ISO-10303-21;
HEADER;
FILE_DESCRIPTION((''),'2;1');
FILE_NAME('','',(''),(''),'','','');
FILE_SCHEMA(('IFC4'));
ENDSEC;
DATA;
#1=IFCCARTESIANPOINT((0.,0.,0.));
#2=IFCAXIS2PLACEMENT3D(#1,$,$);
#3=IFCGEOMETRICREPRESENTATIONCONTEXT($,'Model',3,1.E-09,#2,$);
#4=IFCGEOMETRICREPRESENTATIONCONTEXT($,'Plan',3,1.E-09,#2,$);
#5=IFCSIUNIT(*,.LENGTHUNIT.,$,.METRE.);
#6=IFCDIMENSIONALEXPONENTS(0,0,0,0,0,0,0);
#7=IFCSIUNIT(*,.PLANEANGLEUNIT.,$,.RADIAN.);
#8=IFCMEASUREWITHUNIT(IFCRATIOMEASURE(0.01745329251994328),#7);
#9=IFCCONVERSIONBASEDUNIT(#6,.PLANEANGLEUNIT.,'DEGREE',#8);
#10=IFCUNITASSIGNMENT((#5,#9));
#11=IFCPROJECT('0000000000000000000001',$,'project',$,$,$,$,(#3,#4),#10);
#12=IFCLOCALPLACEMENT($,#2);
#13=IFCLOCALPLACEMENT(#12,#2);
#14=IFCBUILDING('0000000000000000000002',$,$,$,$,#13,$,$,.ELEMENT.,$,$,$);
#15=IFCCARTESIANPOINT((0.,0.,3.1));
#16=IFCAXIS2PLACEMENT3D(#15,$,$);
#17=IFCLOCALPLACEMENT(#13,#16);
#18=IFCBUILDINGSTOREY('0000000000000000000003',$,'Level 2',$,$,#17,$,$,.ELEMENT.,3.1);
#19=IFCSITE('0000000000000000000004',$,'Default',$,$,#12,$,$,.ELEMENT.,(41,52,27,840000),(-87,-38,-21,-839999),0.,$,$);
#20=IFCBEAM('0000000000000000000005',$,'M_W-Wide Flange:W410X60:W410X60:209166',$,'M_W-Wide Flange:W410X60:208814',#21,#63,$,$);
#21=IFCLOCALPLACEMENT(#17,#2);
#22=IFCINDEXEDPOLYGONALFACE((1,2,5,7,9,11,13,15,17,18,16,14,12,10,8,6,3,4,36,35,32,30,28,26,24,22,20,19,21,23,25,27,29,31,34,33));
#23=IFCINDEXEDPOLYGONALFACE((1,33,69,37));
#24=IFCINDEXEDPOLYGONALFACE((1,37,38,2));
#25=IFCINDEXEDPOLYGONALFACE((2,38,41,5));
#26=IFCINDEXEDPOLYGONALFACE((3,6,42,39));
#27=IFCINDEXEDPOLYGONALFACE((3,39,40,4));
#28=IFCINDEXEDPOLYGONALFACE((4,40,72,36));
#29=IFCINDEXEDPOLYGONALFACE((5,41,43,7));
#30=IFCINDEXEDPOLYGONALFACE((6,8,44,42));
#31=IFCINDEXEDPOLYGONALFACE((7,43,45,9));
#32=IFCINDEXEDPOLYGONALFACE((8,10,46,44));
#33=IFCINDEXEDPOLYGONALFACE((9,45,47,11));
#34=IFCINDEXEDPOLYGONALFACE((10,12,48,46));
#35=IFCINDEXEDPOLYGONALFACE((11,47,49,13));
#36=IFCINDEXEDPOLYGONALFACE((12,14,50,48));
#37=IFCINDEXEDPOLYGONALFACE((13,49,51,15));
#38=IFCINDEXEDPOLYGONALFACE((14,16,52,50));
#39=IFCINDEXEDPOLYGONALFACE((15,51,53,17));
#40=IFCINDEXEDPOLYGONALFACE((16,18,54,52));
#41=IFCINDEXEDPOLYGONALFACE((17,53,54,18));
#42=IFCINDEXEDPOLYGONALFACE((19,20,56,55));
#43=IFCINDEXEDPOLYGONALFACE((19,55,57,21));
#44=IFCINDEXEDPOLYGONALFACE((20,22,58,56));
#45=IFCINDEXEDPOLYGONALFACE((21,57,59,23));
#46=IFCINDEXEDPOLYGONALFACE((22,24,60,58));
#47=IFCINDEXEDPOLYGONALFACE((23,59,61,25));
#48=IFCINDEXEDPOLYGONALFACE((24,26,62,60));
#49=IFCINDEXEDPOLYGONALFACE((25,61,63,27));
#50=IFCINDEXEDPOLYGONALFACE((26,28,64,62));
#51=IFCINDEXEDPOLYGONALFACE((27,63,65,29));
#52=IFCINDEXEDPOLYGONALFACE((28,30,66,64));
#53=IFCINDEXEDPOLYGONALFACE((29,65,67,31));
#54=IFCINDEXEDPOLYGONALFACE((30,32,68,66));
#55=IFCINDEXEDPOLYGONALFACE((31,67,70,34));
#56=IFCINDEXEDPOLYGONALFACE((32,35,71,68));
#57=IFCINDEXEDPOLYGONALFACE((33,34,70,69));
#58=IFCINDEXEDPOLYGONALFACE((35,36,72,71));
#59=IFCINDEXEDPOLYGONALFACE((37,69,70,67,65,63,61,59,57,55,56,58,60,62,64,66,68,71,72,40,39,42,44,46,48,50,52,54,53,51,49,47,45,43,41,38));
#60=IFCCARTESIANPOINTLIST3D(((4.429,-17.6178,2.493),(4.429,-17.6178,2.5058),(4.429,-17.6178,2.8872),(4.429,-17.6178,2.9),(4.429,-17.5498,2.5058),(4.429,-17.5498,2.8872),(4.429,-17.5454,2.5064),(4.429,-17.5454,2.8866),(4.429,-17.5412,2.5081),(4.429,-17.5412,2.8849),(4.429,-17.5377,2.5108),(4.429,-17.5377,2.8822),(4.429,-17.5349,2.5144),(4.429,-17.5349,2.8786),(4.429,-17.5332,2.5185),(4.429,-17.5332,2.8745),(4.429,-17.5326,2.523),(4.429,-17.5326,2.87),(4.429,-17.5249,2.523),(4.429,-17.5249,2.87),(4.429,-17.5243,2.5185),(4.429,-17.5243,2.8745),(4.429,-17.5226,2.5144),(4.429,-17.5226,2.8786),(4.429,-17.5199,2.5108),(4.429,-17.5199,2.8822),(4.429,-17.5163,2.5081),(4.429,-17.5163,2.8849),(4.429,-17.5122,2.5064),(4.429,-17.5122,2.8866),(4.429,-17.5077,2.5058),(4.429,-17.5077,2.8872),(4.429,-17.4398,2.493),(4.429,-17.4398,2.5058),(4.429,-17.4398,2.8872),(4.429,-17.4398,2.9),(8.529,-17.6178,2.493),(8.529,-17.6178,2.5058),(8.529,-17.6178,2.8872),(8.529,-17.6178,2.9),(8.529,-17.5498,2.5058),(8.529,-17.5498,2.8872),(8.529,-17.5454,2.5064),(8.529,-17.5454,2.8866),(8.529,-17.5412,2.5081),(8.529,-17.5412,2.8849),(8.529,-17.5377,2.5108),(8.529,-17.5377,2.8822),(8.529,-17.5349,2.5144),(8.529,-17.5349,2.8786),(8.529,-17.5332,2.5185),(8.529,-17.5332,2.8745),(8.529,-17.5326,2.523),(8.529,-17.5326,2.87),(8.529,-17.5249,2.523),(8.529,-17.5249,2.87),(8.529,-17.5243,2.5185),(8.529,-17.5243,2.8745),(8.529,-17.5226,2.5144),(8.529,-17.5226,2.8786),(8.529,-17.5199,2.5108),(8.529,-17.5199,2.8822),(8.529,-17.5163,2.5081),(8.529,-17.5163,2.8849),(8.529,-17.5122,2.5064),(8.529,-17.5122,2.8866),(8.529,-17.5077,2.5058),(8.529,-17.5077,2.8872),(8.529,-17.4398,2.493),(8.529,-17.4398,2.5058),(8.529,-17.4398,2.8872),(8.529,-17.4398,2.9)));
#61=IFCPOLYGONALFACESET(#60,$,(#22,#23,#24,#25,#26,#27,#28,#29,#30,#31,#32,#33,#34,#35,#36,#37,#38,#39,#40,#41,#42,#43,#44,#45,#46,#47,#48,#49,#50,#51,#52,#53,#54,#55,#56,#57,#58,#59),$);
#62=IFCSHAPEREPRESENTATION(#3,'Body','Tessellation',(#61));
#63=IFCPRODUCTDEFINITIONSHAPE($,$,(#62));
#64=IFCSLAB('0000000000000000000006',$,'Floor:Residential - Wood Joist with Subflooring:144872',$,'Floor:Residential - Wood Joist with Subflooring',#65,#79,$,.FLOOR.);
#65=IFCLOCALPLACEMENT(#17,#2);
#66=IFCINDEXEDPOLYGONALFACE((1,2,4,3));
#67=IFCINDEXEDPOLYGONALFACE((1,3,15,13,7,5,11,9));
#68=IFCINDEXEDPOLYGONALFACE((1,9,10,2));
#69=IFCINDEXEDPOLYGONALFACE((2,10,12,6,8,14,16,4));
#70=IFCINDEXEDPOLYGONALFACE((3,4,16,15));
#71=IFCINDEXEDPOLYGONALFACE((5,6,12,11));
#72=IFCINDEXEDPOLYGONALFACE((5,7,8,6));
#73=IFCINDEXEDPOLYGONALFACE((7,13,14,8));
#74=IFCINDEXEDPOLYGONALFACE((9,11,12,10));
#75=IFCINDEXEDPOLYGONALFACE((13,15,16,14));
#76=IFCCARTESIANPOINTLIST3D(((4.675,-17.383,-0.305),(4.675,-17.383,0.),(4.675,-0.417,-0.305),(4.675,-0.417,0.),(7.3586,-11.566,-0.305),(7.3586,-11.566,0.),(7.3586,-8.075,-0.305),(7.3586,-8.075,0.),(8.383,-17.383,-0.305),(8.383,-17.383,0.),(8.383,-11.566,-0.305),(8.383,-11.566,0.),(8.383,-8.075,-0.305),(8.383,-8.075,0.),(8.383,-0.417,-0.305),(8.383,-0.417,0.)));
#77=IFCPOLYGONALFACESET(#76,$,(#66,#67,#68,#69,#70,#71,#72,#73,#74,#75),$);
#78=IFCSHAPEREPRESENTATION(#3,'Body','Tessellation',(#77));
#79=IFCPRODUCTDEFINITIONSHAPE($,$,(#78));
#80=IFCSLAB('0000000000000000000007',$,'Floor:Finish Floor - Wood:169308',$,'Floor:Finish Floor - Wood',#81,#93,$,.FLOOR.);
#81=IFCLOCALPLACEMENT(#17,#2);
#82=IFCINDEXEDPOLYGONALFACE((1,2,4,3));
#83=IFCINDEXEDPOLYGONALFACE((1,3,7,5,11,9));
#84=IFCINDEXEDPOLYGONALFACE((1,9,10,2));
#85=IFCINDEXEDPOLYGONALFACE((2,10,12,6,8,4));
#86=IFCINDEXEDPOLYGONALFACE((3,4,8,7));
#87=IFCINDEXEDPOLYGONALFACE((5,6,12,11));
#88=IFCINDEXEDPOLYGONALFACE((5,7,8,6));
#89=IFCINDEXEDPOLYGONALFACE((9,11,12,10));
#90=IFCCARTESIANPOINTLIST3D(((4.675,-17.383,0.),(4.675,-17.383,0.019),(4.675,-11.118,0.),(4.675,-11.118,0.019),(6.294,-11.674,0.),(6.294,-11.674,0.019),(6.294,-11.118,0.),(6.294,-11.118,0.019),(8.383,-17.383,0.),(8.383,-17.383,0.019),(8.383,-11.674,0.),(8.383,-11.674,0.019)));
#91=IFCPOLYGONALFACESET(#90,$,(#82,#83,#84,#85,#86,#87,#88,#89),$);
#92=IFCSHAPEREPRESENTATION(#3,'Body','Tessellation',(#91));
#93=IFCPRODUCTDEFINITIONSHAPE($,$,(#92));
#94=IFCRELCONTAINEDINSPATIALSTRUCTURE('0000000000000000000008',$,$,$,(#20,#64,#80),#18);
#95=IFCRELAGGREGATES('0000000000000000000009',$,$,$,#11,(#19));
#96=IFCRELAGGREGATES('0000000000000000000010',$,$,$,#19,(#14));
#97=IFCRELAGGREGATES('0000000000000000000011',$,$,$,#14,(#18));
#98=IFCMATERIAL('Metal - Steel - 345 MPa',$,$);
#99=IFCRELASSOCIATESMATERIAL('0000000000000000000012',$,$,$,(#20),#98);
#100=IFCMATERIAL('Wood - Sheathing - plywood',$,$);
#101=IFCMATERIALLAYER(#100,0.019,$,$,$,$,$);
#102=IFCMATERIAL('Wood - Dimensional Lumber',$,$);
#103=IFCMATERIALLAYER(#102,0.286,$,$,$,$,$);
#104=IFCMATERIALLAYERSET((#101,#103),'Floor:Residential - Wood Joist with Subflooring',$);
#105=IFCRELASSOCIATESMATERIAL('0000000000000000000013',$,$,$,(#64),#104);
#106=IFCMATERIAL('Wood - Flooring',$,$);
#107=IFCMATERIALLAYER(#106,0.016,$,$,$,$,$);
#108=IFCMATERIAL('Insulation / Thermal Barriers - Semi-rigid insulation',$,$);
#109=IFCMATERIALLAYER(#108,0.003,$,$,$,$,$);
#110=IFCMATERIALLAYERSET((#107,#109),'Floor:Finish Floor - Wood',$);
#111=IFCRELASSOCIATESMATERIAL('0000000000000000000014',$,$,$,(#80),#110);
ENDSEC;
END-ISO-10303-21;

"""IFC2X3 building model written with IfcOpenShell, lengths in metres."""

from ifc_helpers import new_model, entity, si_unit, converted_unit, frame, frame_2d, origin, place, context, project, spatial, polyline, circle_curve, parameter, trimmed, segment, composite_curve, outline, extrude, material, layer, layer_set, layer_usage, element, save


model = new_model("IFC2X3")

# Units and contexts
model_context = context("Model", 3, precision=1e-09, world=origin())
plan_context = context("Plan", 3, precision=1e-09, world=origin())
ifc_project = project(units=[si_unit("LENGTHUNIT", "METRE"), converted_unit("PLANEANGLEUNIT", "DEGREE", entity("IfcRatioMeasure", 0.01745329251994328), si_unit("PLANEANGLEUNIT", "RADIAN"), dimensions=[0, 0, 0, 0, 0, 0, 0])], contexts=[model_context, plan_context])

# Site, building, storey
site_placement = place(None, origin())
site = spatial("IfcSite", under=ifc_project, at=site_placement, Name="Default", CompositionType="ELEMENT", RefLatitude=(41, 52, 27, 840000), RefLongitude=(-87, -38, -21, -839999), RefElevation=0.0)
building_placement = place(site_placement, origin())
building = spatial("IfcBuilding", under=site, at=building_placement, CompositionType="ELEMENT")
storey_placement = place(building_placement, frame((0.0, 0.0, 3.1)))
storey = spatial("IfcBuildingStorey", under=building, at=storey_placement, Name="Level 2", CompositionType="ELEMENT", Elevation=3.1)

# Beam
ifc_material_1 = material(Name="Metal - Steel - 345 MPa")
beam_placement = place(storey_placement, frame((4.429, -17.5288, 2.9), z_axis=(0.0, 0.0, 1.0), x_axis=(0.0, -1.0, 0.0)))
element("IfcBeam", 1, at=beam_placement, inside=storey, material=ifc_material_1, Name="M_W-Wide Flange:W410X60:W410X60:209166", ObjectType="M_W-Wide Flange:W410X60:208814", context=model_context, shape_type="SweptSolid", body=[
    extrude(outline(composite_curve([segment(polyline([(-0.089, -0.1907), (-0.089, -0.2035)]), True, "CONTINUOUS"), segment(polyline([(-0.089, -0.2035), (0.089, -0.2035)]), True, "CONTINUOUS"), segment(polyline([(0.089, -0.2035), (0.089, -0.1907)]), True, "CONTINUOUS"), segment(polyline([(0.089, -0.1907), (0.021, -0.1907)]), True, "CONTINUOUS"), segment(trimmed(circle_curve(frame_2d((0.021, -0.1735), x_axis=(0.0, -1.0)), 0.0172), [parameter(270.0)], [parameter(360.0)], True, "PARAMETER"), False, "CONTINUOUS"), segment(polyline([(0.0038, -0.1735), (0.0038, 0.1735)]), True, "CONTINUOUS"), segment(trimmed(circle_curve(frame_2d((0.021, 0.1735), x_axis=(-1.0, 0.0)), 0.0172), [parameter(270.0)], [parameter(360.0)], True, "PARAMETER"), False, "CONTINUOUS"), segment(polyline([(0.021, 0.1907), (0.089, 0.1907)]), True, "CONTINUOUS"), segment(polyline([(0.089, 0.1907), (0.089, 0.2035)]), True, "CONTINUOUS"), segment(polyline([(0.089, 0.2035), (-0.089, 0.2035)]), True, "CONTINUOUS"), segment(polyline([(-0.089, 0.2035), (-0.089, 0.1907)]), True, "CONTINUOUS"), segment(polyline([(-0.089, 0.1907), (-0.0211, 0.1907)]), True, "CONTINUOUS"), segment(trimmed(circle_curve(frame_2d((-0.0211, 0.1735), x_axis=(0.0, 1.0)), 0.0172), [parameter(270.0)], [parameter(0.0)], True, "PARAMETER"), False, "CONTINUOUS"), segment(polyline([(-0.0039, 0.1735), (-0.0039, -0.1735)]), True, "CONTINUOUS"), segment(trimmed(circle_curve(frame_2d((-0.0211, -0.1735), x_axis=(1.0, 0.0)), 0.0172), [parameter(270.0)], [parameter(0.0)], True, "PARAMETER"), False, "CONTINUOUS"), segment(polyline([(-0.0211, -0.1907), (-0.089, -0.1907)]), True, "CONTINUOUS")], self_intersect=False)), frame((0.0, 0.0, -0.2035), z_axis=(0.0, -1.0, 0.0), x_axis=(1.0, 0.0, 0.0)), (0.0, 0.0, -1.0), 4.1),
])

# Slabs
ifc_material_2 = material(Name="Wood - Sheathing - plywood")
ifc_layer_1 = layer(ifc_material_2, 0.019)
ifc_material_3 = material(Name="Wood - Dimensional Lumber")
ifc_layer_2 = layer(ifc_material_3, 0.286)
ifc_layer_set_1 = layer_set([ifc_layer_1, ifc_layer_2], Name="Floor:Residential - Wood Joist with Subflooring")
ifc_layer_usage_1 = layer_usage(ifc_layer_set_1, "AXIS3", "POSITIVE", 0.0)
slab_1_placement = place(storey_placement, frame((4.675, -17.383, -0.305)))
element("IfcSlab", 2, at=slab_1_placement, inside=storey, material=ifc_layer_usage_1, Name="Floor:Residential - Wood Joist with Subflooring:144872", ObjectType="Floor:Residential - Wood Joist with Subflooring", PredefinedType="FLOOR", context=model_context, shape_type="SweptSolid", body=[
    extrude(outline(polyline([(-1.854, 8.483), (-1.854, 0.825), (-0.8296, 0.825), (-0.8296, -2.666), (-1.854, -2.666), (-1.854, -8.483), (1.854, -8.483), (1.854, 8.483), (-1.854, 8.483)])), frame((1.854, 8.483, 0.305), z_axis=(0.0, 0.0, -1.0), x_axis=(-1.0, 0.0, 0.0)), (0.0, 0.0, 1.0), 0.305),
])
ifc_material_4 = material(Name="Wood - Flooring")
ifc_layer_3 = layer(ifc_material_4, 0.016)
ifc_material_5 = material(Name="Insulation / Thermal Barriers - Semi-rigid insulation")
ifc_layer_4 = layer(ifc_material_5, 0.003)
ifc_layer_set_2 = layer_set([ifc_layer_3, ifc_layer_4], Name="Floor:Finish Floor - Wood")
ifc_layer_usage_2 = layer_usage(ifc_layer_set_2, "AXIS3", "POSITIVE", 0.0)
slab_2_placement = place(storey_placement, frame((4.675, -17.383, 0.0)))
element("IfcSlab", 3, at=slab_2_placement, inside=storey, material=ifc_layer_usage_2, Name="Floor:Finish Floor - Wood:169308", ObjectType="Floor:Finish Floor - Wood", PredefinedType="FLOOR", context=model_context, shape_type="SweptSolid", body=[
    extrude(outline(polyline([(-1.854, 2.5765), (-1.854, -3.1325), (1.854, -3.1325), (1.854, 3.1325), (0.235, 3.1325), (0.235, 2.5765), (-1.854, 2.5765)])), frame((1.854, 3.1325, 0.019), z_axis=(0.0, 0.0, -1.0), x_axis=(-1.0, 0.0, 0.0)), (0.0, 0.0, 1.0), 0.019),
])

save(model, "model.ifc")
